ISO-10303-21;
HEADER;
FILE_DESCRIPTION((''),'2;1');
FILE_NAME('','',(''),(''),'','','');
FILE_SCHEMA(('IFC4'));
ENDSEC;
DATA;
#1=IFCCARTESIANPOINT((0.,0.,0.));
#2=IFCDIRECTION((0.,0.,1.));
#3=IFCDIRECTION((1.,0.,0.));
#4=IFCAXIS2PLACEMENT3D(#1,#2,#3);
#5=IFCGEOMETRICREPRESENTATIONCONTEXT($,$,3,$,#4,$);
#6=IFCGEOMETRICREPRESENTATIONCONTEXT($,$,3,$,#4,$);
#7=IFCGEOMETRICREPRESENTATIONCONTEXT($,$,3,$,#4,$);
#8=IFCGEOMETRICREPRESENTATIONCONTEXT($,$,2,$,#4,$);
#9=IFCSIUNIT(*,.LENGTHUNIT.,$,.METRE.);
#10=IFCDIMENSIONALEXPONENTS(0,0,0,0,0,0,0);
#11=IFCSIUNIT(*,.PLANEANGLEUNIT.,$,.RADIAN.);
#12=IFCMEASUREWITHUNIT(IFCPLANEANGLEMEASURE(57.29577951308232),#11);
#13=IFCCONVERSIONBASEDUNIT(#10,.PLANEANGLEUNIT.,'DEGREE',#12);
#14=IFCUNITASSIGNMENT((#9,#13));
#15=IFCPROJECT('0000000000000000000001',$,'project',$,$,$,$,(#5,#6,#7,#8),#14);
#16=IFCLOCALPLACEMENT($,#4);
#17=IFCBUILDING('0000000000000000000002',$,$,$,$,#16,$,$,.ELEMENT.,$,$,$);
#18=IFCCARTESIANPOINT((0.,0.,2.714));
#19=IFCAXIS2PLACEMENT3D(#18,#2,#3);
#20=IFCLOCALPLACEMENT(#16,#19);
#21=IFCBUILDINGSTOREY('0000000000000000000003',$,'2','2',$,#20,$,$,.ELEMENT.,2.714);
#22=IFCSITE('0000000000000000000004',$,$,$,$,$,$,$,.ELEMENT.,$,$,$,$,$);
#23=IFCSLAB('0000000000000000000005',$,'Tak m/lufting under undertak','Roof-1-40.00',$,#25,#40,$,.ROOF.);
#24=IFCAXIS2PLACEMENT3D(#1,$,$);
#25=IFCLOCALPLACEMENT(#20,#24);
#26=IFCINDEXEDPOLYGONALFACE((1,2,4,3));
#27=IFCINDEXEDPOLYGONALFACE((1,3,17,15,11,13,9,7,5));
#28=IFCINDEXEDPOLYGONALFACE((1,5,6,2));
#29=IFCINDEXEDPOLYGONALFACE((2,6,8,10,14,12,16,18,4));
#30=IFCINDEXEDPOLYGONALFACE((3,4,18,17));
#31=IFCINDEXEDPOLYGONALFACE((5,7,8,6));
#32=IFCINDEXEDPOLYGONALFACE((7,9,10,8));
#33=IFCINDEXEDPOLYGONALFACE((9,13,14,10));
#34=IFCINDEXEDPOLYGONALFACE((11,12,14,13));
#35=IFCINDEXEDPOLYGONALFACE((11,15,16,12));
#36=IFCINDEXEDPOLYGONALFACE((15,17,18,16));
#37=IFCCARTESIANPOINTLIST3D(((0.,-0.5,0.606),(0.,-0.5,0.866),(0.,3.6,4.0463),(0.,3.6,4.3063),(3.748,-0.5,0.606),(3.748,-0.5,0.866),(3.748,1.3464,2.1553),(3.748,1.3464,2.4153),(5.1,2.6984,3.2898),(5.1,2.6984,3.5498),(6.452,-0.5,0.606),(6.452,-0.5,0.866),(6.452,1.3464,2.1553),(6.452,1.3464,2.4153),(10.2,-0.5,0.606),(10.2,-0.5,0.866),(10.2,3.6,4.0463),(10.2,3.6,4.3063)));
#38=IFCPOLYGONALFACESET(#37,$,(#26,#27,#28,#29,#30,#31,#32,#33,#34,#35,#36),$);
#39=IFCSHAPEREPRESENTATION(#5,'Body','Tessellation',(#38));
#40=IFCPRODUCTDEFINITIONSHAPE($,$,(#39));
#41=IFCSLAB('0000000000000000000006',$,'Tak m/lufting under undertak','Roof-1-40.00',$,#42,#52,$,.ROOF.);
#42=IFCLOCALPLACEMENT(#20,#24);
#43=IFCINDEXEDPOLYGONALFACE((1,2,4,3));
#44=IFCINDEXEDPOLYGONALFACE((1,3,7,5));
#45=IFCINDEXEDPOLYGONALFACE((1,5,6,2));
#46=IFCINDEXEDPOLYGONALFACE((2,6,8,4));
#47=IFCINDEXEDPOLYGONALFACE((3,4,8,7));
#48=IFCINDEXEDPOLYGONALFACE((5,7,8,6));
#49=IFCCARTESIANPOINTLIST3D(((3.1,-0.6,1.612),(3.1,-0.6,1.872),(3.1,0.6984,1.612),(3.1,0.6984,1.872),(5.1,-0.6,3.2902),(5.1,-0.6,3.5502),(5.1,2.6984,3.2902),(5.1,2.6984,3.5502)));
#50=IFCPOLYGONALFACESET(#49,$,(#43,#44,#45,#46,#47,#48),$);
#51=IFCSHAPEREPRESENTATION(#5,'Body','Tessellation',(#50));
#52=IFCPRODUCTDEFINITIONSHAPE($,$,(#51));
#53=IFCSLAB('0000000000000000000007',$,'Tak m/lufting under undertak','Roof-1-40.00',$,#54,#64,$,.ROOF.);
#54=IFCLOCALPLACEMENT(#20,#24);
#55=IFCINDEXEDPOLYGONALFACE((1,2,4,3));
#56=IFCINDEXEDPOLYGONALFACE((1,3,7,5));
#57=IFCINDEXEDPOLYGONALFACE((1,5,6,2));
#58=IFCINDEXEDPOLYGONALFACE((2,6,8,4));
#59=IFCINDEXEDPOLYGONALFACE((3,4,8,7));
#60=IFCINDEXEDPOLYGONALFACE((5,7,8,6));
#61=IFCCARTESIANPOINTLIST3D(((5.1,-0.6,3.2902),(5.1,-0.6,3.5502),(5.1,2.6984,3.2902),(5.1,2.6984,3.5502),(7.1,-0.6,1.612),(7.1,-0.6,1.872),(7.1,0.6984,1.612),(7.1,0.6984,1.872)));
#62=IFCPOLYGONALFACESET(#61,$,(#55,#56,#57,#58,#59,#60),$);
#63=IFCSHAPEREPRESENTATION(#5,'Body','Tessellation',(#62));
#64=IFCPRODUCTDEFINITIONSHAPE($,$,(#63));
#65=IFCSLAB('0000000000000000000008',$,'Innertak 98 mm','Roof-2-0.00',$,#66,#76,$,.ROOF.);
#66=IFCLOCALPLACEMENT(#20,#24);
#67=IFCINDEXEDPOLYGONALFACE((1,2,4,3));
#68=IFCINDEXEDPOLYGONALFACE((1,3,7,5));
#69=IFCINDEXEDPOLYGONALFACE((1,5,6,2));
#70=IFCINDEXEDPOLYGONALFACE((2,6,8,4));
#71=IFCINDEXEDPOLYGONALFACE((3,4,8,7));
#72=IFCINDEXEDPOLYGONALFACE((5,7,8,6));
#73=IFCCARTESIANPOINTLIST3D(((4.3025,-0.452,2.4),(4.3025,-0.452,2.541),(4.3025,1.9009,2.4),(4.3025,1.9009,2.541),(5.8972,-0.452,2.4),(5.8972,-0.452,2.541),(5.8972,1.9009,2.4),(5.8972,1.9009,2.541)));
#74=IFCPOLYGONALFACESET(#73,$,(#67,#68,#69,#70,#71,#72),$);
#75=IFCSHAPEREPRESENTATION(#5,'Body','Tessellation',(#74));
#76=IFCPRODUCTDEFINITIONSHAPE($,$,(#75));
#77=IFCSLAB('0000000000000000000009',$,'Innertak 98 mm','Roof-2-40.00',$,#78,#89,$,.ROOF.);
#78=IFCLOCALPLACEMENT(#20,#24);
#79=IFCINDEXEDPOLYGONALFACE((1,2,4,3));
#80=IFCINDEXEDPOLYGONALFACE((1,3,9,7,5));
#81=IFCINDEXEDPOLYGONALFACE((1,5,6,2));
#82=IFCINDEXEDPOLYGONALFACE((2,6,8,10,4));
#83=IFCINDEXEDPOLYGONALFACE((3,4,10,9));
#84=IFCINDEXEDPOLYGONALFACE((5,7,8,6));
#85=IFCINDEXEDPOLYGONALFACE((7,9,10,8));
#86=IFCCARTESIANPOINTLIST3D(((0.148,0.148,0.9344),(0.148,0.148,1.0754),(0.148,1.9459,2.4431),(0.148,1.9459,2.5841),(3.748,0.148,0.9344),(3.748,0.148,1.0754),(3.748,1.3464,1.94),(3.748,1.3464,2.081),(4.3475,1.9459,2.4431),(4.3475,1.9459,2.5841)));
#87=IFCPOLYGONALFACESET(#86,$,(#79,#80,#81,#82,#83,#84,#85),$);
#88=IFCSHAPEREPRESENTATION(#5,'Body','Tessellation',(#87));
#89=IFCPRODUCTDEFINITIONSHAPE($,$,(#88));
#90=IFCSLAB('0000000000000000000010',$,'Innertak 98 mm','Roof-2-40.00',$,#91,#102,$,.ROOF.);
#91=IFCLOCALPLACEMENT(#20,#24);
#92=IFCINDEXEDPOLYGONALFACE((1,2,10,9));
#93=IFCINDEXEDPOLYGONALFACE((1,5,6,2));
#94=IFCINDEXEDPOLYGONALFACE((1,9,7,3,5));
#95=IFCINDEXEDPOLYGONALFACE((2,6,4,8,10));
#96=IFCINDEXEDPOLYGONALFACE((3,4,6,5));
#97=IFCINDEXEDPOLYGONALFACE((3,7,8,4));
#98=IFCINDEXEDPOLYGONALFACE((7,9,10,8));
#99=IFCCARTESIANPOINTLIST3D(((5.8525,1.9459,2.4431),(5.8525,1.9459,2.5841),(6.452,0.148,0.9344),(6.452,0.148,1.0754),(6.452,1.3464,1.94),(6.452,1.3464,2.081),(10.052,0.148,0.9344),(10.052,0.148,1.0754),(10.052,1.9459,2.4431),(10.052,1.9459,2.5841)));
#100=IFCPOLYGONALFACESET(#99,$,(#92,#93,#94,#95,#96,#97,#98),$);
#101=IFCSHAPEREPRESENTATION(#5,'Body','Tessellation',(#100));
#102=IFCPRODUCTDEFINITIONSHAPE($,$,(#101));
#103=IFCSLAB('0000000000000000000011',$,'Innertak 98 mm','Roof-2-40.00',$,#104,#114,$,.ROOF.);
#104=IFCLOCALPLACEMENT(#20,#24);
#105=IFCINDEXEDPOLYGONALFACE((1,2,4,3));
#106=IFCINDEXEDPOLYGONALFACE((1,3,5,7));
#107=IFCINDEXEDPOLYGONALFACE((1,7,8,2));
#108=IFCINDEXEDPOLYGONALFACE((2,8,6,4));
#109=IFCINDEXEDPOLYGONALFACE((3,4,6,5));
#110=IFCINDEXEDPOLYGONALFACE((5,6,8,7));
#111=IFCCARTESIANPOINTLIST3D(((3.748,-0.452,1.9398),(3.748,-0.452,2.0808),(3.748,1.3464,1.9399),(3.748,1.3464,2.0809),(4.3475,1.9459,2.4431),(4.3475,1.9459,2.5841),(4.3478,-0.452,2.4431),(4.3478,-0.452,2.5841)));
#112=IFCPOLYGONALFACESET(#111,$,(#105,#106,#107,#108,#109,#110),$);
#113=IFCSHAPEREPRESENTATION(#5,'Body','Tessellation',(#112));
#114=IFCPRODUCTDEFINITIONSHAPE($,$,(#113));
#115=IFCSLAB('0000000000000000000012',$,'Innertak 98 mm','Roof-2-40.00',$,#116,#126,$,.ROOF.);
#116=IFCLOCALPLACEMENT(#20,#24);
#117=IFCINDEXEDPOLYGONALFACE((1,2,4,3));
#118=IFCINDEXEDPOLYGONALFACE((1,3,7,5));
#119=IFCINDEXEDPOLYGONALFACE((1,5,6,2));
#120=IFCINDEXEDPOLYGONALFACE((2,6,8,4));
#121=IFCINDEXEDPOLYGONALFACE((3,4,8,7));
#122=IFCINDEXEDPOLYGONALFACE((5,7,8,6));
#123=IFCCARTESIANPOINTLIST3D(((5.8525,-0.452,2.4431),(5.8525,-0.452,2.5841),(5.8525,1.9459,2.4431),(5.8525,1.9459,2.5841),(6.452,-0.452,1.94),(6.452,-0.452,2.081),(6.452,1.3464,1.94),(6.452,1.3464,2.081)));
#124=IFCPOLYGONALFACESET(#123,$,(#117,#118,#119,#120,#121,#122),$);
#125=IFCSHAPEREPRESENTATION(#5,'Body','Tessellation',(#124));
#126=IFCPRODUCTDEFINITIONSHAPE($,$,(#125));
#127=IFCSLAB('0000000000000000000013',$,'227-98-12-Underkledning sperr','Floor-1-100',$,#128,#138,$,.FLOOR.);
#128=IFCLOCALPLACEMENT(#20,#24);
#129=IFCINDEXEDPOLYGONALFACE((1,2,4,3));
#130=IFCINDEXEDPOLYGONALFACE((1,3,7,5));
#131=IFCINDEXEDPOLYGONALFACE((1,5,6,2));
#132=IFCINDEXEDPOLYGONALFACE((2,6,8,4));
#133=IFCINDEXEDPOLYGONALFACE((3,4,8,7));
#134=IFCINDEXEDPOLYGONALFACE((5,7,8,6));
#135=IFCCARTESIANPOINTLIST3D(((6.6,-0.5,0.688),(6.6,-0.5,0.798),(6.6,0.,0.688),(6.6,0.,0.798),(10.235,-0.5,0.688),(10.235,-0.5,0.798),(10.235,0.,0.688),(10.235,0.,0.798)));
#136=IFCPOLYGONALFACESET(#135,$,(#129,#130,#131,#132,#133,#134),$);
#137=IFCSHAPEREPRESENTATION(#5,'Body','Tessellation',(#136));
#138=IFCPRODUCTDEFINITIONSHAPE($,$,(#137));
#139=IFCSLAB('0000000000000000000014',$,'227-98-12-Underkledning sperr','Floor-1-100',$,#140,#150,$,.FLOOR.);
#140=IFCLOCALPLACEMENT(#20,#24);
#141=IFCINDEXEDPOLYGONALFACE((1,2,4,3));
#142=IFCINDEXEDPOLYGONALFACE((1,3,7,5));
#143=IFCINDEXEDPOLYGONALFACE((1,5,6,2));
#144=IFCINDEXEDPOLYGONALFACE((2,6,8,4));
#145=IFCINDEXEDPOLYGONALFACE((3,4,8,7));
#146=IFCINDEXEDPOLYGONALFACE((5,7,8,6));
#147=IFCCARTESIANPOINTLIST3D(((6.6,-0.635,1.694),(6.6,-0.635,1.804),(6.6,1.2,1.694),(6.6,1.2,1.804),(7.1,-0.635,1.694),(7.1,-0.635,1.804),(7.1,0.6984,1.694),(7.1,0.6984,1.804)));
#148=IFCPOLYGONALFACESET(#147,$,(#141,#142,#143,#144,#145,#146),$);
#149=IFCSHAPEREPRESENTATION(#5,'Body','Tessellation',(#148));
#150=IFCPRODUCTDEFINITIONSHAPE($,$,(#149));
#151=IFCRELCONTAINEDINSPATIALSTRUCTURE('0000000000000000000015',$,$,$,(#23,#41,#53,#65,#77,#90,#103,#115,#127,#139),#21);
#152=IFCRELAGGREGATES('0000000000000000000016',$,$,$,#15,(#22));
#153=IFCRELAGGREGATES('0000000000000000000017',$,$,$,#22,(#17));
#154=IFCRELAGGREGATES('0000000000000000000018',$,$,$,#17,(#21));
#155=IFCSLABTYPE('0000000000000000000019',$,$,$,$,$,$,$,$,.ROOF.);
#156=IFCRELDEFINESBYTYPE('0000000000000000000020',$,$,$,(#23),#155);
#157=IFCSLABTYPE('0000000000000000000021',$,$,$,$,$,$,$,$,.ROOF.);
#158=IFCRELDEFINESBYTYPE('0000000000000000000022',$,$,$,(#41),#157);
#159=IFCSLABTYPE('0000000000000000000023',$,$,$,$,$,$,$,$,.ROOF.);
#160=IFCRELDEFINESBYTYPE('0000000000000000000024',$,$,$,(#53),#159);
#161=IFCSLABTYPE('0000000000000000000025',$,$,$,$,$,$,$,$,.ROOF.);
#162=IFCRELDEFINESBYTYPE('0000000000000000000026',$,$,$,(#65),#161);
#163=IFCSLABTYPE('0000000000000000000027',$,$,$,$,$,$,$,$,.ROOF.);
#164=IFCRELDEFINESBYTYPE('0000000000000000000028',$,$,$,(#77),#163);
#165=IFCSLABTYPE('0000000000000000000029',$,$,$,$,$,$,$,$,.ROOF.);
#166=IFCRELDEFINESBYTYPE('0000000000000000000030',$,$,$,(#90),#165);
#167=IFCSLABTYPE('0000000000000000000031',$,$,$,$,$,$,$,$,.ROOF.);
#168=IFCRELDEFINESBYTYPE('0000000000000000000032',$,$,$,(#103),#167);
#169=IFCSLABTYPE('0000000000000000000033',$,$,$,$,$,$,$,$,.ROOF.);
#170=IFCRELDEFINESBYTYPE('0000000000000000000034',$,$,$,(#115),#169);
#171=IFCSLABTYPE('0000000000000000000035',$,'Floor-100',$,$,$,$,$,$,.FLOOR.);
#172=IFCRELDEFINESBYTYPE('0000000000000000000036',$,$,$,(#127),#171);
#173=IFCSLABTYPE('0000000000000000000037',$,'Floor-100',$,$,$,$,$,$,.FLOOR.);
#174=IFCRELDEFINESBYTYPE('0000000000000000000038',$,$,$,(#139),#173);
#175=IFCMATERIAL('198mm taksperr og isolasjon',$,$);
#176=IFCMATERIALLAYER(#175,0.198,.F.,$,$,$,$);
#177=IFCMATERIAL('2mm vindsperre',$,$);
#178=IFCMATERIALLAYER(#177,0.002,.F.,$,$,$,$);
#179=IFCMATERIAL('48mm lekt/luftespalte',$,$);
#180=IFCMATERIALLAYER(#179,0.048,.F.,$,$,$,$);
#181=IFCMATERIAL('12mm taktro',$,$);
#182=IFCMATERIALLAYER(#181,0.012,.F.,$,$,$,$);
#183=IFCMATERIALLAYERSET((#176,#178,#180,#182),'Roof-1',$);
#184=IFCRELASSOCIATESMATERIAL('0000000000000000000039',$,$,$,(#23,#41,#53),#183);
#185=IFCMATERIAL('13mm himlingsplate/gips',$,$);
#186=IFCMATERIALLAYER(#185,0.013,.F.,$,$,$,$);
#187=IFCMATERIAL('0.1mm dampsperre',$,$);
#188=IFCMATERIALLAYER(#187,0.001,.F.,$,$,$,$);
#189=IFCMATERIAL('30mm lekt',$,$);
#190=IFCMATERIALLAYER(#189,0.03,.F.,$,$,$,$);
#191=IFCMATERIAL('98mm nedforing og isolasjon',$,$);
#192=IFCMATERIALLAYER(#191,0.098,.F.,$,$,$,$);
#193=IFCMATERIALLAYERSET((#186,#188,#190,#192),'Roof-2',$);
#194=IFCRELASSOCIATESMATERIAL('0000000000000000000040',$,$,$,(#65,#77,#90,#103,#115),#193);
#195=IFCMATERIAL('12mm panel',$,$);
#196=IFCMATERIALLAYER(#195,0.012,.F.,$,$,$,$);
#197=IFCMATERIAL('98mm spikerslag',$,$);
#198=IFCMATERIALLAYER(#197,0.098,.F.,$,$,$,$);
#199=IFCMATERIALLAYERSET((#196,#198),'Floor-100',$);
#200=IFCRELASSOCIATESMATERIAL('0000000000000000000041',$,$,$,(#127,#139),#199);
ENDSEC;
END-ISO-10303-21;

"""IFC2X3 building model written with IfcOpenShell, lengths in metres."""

from ifc_helpers import new_model, entity, si_unit, converted_unit, frame, origin_with_axes, place, context, project, spatial, polyline, outline, extrude, material, layer, layer_set, layer_usage, type_object, element, save


model = new_model("IFC2X3")

# Units and contexts
context_of_model_1 = context(None, 3, world=origin_with_axes())
context_of_model_2 = context(None, 3, world=origin_with_axes())
context_of_model_3 = context(None, 3, world=origin_with_axes())
context_of_model_4 = context(None, 2, world=origin_with_axes())
ifc_project = project(units=[si_unit("LENGTHUNIT", "METRE"), converted_unit("PLANEANGLEUNIT", "DEGREE", entity("IfcPlaneAngleMeasure", 57.29577951308232), si_unit("PLANEANGLEUNIT", "RADIAN"), dimensions=[0, 0, 0, 0, 0, 0, 0])], contexts=[context_of_model_1, context_of_model_2, context_of_model_3, context_of_model_4])

# Site, building, storey
site = spatial("IfcSite", under=ifc_project, CompositionType="ELEMENT")
building_placement = place(None, origin_with_axes())
building = spatial("IfcBuilding", under=site, at=building_placement, CompositionType="ELEMENT")
storey_placement = place(building_placement, frame((0.0, 0.0, 2.714), z_axis=(0.0, 0.0, 1.0), x_axis=(1.0, 0.0, 0.0)))
storey = spatial("IfcBuildingStorey", under=building, at=storey_placement, Name="2", Description="2", CompositionType="ELEMENT", Elevation=2.714)

# Slabs
ifc_material_1 = material(Name="198mm taksperr og isolasjon")
ifc_layer_1 = layer(ifc_material_1, 0.198, ventilated=False)
ifc_material_2 = material(Name="2mm vindsperre")
ifc_layer_2 = layer(ifc_material_2, 0.002, ventilated=False)
ifc_material_3 = material(Name="48mm lekt/luftespalte")
ifc_layer_3 = layer(ifc_material_3, 0.048, ventilated=False)
ifc_material_4 = material(Name="12mm taktro")
ifc_layer_4 = layer(ifc_material_4, 0.012, ventilated=False)
ifc_layer_set_1 = layer_set([ifc_layer_1, ifc_layer_2, ifc_layer_3, ifc_layer_4], Name="Roof-1")
ifc_layer_usage_1 = layer_usage(ifc_layer_set_1, "AXIS3", "NEGATIVE", 0.0)
slab_type_1 = type_object("IfcSlabType", PredefinedType="ROOF")
slab_1_placement = place(storey_placement, frame((10.2, 3.6, 4.0463), z_axis=(0.0, -0.642788, 0.766044), x_axis=(-1.0, 0.0, 0.0)))
element("IfcSlab", 1, at=slab_1_placement, inside=storey, type_object=slab_type_1, material=ifc_layer_usage_1, Name="Tak m/lufting under undertak", Description="Roof-1-40.00", PredefinedType="ROOF", context=context_of_model_1, shape_type="SweptSolid", body=[
    extrude(outline(polyline([(0.0, 0.0), (5.3522, 0.0), (5.3522, 3.748), (2.9419, 3.748), (1.1769, 5.1), (2.9419, 6.452), (5.3522, 6.452), (5.3522, 10.2), (0.0, 10.2), (0.0, 0.0)])), frame((0.0, 0.0, 0.0), z_axis=(0.0, 0.0, -1.0), x_axis=(0.0, 1.0, 0.0)), (-0.642788, 0.0, -0.766044), 0.26),
])
slab_type_2 = type_object("IfcSlabType", PredefinedType="ROOF")
slab_2_placement = place(storey_placement, frame((5.1, -0.6, 3.2902), z_axis=(-0.642788, 0.0, 0.766044), x_axis=(0.0, 1.0, 0.0)))
element("IfcSlab", 2, at=slab_2_placement, inside=storey, type_object=slab_type_2, material=ifc_layer_usage_1, Name="Tak m/lufting under undertak", Description="Roof-1-40.00", PredefinedType="ROOF", context=context_of_model_1, shape_type="SweptSolid", body=[
    extrude(outline(polyline([(0.0, 0.0), (2.6108, 0.0), (2.6108, 1.2984), (0.0, 3.2984), (0.0, 0.0)])), frame((0.0, 0.0, 0.0), z_axis=(0.0, 0.0, -1.0), x_axis=(0.0, 1.0, 0.0)), (-0.642788, 0.0, -0.766044), 0.26),
])
slab_type_3 = type_object("IfcSlabType", PredefinedType="ROOF")
slab_3_placement = place(storey_placement, frame((5.1, 2.6984, 3.2902), z_axis=(0.642788, 0.0, 0.766044), x_axis=(0.0, -1.0, 0.0)))
element("IfcSlab", 3, at=slab_3_placement, inside=storey, type_object=slab_type_3, material=ifc_layer_usage_1, Name="Tak m/lufting under undertak", Description="Roof-1-40.00", PredefinedType="ROOF", context=context_of_model_1, shape_type="SweptSolid", body=[
    extrude(outline(polyline([(0.0, 0.0), (3.2984, 0.0), (3.2984, 2.6108), (2.0, 2.6108), (0.0, 0.0)])), origin_with_axes(), (0.0, -0.642788, 0.766044), 0.26),
])
ifc_material_5 = material(Name="13mm himlingsplate/gips")
ifc_layer_5 = layer(ifc_material_5, 0.013, ventilated=False)
ifc_material_6 = material(Name="0.1mm dampsperre")
ifc_layer_6 = layer(ifc_material_6, 0.001, ventilated=False)
ifc_material_7 = material(Name="30mm lekt")
ifc_layer_7 = layer(ifc_material_7, 0.03, ventilated=False)
ifc_material_8 = material(Name="98mm nedforing og isolasjon")
ifc_layer_8 = layer(ifc_material_8, 0.098, ventilated=False)
ifc_layer_set_2 = layer_set([ifc_layer_5, ifc_layer_6, ifc_layer_7, ifc_layer_8], Name="Roof-2")
ifc_layer_usage_2 = layer_usage(ifc_layer_set_2, "AXIS3", "NEGATIVE", 0.0)
slab_type_4 = type_object("IfcSlabType", PredefinedType="ROOF")
slab_4_placement = place(storey_placement, frame((4.3025, -0.452, 2.4), z_axis=(0.0, 0.0, 1.0), x_axis=(1.0, 0.0, 0.0)))
element("IfcSlab", 4, at=slab_4_placement, inside=storey, type_object=slab_type_4, material=ifc_layer_usage_2, Name="Innertak 98 mm", Description="Roof-2-0.00", PredefinedType="ROOF", context=context_of_model_1, shape_type="SweptSolid", body=[
    extrude(outline(polyline([(0.0, 0.0), (1.5947, 0.0), (1.5947, 2.3529), (0.0, 2.3529), (0.0, 0.0)])), origin_with_axes(), (0.0, 0.0, 1.0), 0.141),
])
slab_type_5 = type_object("IfcSlabType", PredefinedType="ROOF")
slab_5_placement = place(storey_placement, frame((4.3475, 1.9459, 2.4431), z_axis=(0.0, -0.642788, 0.766044), x_axis=(-1.0, 0.0, 0.0)))
element("IfcSlab", 5, at=slab_5_placement, inside=storey, type_object=slab_type_5, material=ifc_layer_usage_2, Name="Innertak 98 mm", Description="Roof-2-40.00", PredefinedType="ROOF", context=context_of_model_1, shape_type="SweptSolid", body=[
    extrude(outline(polyline([(0.0, 0.0), (4.1995, 0.0), (4.1995, 2.347), (0.5995, 2.347), (0.5995, 0.7826), (0.0, 0.0)])), frame((0.0, 0.0, 0.0), z_axis=(0.0, 0.0, 1.0), x_axis=(1.0, 0.0, 0.0)), (0.0, -0.642788, 0.766044), 0.141),
])
slab_type_6 = type_object("IfcSlabType", PredefinedType="ROOF")
slab_6_placement = place(storey_placement, frame((10.052, 1.9459, 2.4431), z_axis=(0.0, -0.642788, 0.766044), x_axis=(-1.0, 0.0, 0.0)))
element("IfcSlab", 6, at=slab_6_placement, inside=storey, type_object=slab_type_6, material=ifc_layer_usage_2, Name="Innertak 98 mm", Description="Roof-2-40.00", PredefinedType="ROOF", context=context_of_model_1, shape_type="SweptSolid", body=[
    extrude(outline(polyline([(0.0, 0.0), (4.1995, 0.0), (3.6, 0.7826), (3.6, 2.347), (0.0, 2.347), (0.0, 0.0)])), frame((0.0, 0.0, 0.0), z_axis=(0.0, 0.0, 1.0), x_axis=(1.0, 0.0, 0.0)), (0.0, -0.642788, 0.766044), 0.141),
])
slab_type_7 = type_object("IfcSlabType", PredefinedType="ROOF")
slab_7_placement = place(storey_placement, frame((4.3478, -0.452, 2.4431), z_axis=(-0.642787, -0.000078, 0.766045), x_axis=(-0.000121, 1.0, 0.0)))
element("IfcSlab", 7, at=slab_7_placement, inside=storey, type_object=slab_type_7, material=ifc_layer_usage_2, Name="Innertak 98 mm", Description="Roof-2-40.00", PredefinedType="ROOF", context=context_of_model_1, shape_type="SweptSolid", body=[
    extrude(outline(polyline([(0.0, 0.0), (0.783, 0.0), (0.7829, 1.7984), (0.0002, 2.3979), (0.0, 0.0)])), frame((0.0, 0.0, 0.0), z_axis=(0.0, 0.0, -1.0), x_axis=(0.000093, 1.0, 0.0)), (-0.642787, 0.00006, -0.766045), 0.141),
])
slab_type_8 = type_object("IfcSlabType", PredefinedType="ROOF")
slab_8_placement = place(storey_placement, frame((5.8525, 1.9459, 2.4431), z_axis=(0.642788, 0.000001, 0.766045), x_axis=(0.000001, -1.0, 0.0)))
element("IfcSlab", 8, at=slab_8_placement, inside=storey, type_object=slab_type_8, material=ifc_layer_usage_2, Name="Innertak 98 mm", Description="Roof-2-40.00", PredefinedType="ROOF", context=context_of_model_1, shape_type="SweptSolid", body=[
    extrude(outline(polyline([(0.0, 0.0), (2.3979, 0.0), (2.3979, 0.7826), (0.5995, 0.7826), (0.0, 0.0)])), origin_with_axes(), (0.0, -0.642788, 0.766044), 0.141),
])
ifc_material_9 = material(Name="12mm panel")
ifc_layer_9 = layer(ifc_material_9, 0.012, ventilated=False)
ifc_material_10 = material(Name="98mm spikerslag")
ifc_layer_10 = layer(ifc_material_10, 0.098, ventilated=False)
ifc_layer_set_3 = layer_set([ifc_layer_9, ifc_layer_10], Name="Floor-100")
ifc_layer_usage_3 = layer_usage(ifc_layer_set_3, "AXIS3", "NEGATIVE", 0.0)
slab_type_9 = type_object("IfcSlabType", Name="Floor-100", PredefinedType="FLOOR")
slab_9_placement = place(storey_placement, frame((6.6, -0.5, 0.688), z_axis=(0.0, 0.0, 1.0), x_axis=(1.0, 0.0, 0.0)))
element("IfcSlab", 9, at=slab_9_placement, inside=storey, type_object=slab_type_9, material=ifc_layer_usage_3, Name="227-98-12-Underkledning sperr", Description="Floor-1-100", PredefinedType="FLOOR", context=context_of_model_1, shape_type="SweptSolid", body=[
    extrude(outline(polyline([(0.0, 0.0), (3.635, 0.0), (3.635, 0.5), (0.0, 0.5), (0.0, 0.0)])), origin_with_axes(), (0.0, 0.0, 1.0), 0.11),
])
slab_type_10 = type_object("IfcSlabType", Name="Floor-100", PredefinedType="FLOOR")
slab_10_placement = place(storey_placement, frame((6.6, -0.635, 1.694), z_axis=(0.0, 0.0, 1.0), x_axis=(1.0, 0.0, 0.0)))
element("IfcSlab", 10, at=slab_10_placement, inside=storey, type_object=slab_type_10, material=ifc_layer_usage_3, Name="227-98-12-Underkledning sperr", Description="Floor-1-100", PredefinedType="FLOOR", context=context_of_model_1, shape_type="SweptSolid", body=[
    extrude(outline(polyline([(0.0, 0.0), (0.5, 0.0), (0.5, 1.3334), (0.0, 1.835), (0.0, 0.0)])), frame((0.0, 0.0, 0.0), z_axis=(0.0, 0.0, 1.0), x_axis=(1.0, 0.000006, 0.0)), (0.0, 0.0, 1.0), 0.11),
])

save(model, "model.ifc")
